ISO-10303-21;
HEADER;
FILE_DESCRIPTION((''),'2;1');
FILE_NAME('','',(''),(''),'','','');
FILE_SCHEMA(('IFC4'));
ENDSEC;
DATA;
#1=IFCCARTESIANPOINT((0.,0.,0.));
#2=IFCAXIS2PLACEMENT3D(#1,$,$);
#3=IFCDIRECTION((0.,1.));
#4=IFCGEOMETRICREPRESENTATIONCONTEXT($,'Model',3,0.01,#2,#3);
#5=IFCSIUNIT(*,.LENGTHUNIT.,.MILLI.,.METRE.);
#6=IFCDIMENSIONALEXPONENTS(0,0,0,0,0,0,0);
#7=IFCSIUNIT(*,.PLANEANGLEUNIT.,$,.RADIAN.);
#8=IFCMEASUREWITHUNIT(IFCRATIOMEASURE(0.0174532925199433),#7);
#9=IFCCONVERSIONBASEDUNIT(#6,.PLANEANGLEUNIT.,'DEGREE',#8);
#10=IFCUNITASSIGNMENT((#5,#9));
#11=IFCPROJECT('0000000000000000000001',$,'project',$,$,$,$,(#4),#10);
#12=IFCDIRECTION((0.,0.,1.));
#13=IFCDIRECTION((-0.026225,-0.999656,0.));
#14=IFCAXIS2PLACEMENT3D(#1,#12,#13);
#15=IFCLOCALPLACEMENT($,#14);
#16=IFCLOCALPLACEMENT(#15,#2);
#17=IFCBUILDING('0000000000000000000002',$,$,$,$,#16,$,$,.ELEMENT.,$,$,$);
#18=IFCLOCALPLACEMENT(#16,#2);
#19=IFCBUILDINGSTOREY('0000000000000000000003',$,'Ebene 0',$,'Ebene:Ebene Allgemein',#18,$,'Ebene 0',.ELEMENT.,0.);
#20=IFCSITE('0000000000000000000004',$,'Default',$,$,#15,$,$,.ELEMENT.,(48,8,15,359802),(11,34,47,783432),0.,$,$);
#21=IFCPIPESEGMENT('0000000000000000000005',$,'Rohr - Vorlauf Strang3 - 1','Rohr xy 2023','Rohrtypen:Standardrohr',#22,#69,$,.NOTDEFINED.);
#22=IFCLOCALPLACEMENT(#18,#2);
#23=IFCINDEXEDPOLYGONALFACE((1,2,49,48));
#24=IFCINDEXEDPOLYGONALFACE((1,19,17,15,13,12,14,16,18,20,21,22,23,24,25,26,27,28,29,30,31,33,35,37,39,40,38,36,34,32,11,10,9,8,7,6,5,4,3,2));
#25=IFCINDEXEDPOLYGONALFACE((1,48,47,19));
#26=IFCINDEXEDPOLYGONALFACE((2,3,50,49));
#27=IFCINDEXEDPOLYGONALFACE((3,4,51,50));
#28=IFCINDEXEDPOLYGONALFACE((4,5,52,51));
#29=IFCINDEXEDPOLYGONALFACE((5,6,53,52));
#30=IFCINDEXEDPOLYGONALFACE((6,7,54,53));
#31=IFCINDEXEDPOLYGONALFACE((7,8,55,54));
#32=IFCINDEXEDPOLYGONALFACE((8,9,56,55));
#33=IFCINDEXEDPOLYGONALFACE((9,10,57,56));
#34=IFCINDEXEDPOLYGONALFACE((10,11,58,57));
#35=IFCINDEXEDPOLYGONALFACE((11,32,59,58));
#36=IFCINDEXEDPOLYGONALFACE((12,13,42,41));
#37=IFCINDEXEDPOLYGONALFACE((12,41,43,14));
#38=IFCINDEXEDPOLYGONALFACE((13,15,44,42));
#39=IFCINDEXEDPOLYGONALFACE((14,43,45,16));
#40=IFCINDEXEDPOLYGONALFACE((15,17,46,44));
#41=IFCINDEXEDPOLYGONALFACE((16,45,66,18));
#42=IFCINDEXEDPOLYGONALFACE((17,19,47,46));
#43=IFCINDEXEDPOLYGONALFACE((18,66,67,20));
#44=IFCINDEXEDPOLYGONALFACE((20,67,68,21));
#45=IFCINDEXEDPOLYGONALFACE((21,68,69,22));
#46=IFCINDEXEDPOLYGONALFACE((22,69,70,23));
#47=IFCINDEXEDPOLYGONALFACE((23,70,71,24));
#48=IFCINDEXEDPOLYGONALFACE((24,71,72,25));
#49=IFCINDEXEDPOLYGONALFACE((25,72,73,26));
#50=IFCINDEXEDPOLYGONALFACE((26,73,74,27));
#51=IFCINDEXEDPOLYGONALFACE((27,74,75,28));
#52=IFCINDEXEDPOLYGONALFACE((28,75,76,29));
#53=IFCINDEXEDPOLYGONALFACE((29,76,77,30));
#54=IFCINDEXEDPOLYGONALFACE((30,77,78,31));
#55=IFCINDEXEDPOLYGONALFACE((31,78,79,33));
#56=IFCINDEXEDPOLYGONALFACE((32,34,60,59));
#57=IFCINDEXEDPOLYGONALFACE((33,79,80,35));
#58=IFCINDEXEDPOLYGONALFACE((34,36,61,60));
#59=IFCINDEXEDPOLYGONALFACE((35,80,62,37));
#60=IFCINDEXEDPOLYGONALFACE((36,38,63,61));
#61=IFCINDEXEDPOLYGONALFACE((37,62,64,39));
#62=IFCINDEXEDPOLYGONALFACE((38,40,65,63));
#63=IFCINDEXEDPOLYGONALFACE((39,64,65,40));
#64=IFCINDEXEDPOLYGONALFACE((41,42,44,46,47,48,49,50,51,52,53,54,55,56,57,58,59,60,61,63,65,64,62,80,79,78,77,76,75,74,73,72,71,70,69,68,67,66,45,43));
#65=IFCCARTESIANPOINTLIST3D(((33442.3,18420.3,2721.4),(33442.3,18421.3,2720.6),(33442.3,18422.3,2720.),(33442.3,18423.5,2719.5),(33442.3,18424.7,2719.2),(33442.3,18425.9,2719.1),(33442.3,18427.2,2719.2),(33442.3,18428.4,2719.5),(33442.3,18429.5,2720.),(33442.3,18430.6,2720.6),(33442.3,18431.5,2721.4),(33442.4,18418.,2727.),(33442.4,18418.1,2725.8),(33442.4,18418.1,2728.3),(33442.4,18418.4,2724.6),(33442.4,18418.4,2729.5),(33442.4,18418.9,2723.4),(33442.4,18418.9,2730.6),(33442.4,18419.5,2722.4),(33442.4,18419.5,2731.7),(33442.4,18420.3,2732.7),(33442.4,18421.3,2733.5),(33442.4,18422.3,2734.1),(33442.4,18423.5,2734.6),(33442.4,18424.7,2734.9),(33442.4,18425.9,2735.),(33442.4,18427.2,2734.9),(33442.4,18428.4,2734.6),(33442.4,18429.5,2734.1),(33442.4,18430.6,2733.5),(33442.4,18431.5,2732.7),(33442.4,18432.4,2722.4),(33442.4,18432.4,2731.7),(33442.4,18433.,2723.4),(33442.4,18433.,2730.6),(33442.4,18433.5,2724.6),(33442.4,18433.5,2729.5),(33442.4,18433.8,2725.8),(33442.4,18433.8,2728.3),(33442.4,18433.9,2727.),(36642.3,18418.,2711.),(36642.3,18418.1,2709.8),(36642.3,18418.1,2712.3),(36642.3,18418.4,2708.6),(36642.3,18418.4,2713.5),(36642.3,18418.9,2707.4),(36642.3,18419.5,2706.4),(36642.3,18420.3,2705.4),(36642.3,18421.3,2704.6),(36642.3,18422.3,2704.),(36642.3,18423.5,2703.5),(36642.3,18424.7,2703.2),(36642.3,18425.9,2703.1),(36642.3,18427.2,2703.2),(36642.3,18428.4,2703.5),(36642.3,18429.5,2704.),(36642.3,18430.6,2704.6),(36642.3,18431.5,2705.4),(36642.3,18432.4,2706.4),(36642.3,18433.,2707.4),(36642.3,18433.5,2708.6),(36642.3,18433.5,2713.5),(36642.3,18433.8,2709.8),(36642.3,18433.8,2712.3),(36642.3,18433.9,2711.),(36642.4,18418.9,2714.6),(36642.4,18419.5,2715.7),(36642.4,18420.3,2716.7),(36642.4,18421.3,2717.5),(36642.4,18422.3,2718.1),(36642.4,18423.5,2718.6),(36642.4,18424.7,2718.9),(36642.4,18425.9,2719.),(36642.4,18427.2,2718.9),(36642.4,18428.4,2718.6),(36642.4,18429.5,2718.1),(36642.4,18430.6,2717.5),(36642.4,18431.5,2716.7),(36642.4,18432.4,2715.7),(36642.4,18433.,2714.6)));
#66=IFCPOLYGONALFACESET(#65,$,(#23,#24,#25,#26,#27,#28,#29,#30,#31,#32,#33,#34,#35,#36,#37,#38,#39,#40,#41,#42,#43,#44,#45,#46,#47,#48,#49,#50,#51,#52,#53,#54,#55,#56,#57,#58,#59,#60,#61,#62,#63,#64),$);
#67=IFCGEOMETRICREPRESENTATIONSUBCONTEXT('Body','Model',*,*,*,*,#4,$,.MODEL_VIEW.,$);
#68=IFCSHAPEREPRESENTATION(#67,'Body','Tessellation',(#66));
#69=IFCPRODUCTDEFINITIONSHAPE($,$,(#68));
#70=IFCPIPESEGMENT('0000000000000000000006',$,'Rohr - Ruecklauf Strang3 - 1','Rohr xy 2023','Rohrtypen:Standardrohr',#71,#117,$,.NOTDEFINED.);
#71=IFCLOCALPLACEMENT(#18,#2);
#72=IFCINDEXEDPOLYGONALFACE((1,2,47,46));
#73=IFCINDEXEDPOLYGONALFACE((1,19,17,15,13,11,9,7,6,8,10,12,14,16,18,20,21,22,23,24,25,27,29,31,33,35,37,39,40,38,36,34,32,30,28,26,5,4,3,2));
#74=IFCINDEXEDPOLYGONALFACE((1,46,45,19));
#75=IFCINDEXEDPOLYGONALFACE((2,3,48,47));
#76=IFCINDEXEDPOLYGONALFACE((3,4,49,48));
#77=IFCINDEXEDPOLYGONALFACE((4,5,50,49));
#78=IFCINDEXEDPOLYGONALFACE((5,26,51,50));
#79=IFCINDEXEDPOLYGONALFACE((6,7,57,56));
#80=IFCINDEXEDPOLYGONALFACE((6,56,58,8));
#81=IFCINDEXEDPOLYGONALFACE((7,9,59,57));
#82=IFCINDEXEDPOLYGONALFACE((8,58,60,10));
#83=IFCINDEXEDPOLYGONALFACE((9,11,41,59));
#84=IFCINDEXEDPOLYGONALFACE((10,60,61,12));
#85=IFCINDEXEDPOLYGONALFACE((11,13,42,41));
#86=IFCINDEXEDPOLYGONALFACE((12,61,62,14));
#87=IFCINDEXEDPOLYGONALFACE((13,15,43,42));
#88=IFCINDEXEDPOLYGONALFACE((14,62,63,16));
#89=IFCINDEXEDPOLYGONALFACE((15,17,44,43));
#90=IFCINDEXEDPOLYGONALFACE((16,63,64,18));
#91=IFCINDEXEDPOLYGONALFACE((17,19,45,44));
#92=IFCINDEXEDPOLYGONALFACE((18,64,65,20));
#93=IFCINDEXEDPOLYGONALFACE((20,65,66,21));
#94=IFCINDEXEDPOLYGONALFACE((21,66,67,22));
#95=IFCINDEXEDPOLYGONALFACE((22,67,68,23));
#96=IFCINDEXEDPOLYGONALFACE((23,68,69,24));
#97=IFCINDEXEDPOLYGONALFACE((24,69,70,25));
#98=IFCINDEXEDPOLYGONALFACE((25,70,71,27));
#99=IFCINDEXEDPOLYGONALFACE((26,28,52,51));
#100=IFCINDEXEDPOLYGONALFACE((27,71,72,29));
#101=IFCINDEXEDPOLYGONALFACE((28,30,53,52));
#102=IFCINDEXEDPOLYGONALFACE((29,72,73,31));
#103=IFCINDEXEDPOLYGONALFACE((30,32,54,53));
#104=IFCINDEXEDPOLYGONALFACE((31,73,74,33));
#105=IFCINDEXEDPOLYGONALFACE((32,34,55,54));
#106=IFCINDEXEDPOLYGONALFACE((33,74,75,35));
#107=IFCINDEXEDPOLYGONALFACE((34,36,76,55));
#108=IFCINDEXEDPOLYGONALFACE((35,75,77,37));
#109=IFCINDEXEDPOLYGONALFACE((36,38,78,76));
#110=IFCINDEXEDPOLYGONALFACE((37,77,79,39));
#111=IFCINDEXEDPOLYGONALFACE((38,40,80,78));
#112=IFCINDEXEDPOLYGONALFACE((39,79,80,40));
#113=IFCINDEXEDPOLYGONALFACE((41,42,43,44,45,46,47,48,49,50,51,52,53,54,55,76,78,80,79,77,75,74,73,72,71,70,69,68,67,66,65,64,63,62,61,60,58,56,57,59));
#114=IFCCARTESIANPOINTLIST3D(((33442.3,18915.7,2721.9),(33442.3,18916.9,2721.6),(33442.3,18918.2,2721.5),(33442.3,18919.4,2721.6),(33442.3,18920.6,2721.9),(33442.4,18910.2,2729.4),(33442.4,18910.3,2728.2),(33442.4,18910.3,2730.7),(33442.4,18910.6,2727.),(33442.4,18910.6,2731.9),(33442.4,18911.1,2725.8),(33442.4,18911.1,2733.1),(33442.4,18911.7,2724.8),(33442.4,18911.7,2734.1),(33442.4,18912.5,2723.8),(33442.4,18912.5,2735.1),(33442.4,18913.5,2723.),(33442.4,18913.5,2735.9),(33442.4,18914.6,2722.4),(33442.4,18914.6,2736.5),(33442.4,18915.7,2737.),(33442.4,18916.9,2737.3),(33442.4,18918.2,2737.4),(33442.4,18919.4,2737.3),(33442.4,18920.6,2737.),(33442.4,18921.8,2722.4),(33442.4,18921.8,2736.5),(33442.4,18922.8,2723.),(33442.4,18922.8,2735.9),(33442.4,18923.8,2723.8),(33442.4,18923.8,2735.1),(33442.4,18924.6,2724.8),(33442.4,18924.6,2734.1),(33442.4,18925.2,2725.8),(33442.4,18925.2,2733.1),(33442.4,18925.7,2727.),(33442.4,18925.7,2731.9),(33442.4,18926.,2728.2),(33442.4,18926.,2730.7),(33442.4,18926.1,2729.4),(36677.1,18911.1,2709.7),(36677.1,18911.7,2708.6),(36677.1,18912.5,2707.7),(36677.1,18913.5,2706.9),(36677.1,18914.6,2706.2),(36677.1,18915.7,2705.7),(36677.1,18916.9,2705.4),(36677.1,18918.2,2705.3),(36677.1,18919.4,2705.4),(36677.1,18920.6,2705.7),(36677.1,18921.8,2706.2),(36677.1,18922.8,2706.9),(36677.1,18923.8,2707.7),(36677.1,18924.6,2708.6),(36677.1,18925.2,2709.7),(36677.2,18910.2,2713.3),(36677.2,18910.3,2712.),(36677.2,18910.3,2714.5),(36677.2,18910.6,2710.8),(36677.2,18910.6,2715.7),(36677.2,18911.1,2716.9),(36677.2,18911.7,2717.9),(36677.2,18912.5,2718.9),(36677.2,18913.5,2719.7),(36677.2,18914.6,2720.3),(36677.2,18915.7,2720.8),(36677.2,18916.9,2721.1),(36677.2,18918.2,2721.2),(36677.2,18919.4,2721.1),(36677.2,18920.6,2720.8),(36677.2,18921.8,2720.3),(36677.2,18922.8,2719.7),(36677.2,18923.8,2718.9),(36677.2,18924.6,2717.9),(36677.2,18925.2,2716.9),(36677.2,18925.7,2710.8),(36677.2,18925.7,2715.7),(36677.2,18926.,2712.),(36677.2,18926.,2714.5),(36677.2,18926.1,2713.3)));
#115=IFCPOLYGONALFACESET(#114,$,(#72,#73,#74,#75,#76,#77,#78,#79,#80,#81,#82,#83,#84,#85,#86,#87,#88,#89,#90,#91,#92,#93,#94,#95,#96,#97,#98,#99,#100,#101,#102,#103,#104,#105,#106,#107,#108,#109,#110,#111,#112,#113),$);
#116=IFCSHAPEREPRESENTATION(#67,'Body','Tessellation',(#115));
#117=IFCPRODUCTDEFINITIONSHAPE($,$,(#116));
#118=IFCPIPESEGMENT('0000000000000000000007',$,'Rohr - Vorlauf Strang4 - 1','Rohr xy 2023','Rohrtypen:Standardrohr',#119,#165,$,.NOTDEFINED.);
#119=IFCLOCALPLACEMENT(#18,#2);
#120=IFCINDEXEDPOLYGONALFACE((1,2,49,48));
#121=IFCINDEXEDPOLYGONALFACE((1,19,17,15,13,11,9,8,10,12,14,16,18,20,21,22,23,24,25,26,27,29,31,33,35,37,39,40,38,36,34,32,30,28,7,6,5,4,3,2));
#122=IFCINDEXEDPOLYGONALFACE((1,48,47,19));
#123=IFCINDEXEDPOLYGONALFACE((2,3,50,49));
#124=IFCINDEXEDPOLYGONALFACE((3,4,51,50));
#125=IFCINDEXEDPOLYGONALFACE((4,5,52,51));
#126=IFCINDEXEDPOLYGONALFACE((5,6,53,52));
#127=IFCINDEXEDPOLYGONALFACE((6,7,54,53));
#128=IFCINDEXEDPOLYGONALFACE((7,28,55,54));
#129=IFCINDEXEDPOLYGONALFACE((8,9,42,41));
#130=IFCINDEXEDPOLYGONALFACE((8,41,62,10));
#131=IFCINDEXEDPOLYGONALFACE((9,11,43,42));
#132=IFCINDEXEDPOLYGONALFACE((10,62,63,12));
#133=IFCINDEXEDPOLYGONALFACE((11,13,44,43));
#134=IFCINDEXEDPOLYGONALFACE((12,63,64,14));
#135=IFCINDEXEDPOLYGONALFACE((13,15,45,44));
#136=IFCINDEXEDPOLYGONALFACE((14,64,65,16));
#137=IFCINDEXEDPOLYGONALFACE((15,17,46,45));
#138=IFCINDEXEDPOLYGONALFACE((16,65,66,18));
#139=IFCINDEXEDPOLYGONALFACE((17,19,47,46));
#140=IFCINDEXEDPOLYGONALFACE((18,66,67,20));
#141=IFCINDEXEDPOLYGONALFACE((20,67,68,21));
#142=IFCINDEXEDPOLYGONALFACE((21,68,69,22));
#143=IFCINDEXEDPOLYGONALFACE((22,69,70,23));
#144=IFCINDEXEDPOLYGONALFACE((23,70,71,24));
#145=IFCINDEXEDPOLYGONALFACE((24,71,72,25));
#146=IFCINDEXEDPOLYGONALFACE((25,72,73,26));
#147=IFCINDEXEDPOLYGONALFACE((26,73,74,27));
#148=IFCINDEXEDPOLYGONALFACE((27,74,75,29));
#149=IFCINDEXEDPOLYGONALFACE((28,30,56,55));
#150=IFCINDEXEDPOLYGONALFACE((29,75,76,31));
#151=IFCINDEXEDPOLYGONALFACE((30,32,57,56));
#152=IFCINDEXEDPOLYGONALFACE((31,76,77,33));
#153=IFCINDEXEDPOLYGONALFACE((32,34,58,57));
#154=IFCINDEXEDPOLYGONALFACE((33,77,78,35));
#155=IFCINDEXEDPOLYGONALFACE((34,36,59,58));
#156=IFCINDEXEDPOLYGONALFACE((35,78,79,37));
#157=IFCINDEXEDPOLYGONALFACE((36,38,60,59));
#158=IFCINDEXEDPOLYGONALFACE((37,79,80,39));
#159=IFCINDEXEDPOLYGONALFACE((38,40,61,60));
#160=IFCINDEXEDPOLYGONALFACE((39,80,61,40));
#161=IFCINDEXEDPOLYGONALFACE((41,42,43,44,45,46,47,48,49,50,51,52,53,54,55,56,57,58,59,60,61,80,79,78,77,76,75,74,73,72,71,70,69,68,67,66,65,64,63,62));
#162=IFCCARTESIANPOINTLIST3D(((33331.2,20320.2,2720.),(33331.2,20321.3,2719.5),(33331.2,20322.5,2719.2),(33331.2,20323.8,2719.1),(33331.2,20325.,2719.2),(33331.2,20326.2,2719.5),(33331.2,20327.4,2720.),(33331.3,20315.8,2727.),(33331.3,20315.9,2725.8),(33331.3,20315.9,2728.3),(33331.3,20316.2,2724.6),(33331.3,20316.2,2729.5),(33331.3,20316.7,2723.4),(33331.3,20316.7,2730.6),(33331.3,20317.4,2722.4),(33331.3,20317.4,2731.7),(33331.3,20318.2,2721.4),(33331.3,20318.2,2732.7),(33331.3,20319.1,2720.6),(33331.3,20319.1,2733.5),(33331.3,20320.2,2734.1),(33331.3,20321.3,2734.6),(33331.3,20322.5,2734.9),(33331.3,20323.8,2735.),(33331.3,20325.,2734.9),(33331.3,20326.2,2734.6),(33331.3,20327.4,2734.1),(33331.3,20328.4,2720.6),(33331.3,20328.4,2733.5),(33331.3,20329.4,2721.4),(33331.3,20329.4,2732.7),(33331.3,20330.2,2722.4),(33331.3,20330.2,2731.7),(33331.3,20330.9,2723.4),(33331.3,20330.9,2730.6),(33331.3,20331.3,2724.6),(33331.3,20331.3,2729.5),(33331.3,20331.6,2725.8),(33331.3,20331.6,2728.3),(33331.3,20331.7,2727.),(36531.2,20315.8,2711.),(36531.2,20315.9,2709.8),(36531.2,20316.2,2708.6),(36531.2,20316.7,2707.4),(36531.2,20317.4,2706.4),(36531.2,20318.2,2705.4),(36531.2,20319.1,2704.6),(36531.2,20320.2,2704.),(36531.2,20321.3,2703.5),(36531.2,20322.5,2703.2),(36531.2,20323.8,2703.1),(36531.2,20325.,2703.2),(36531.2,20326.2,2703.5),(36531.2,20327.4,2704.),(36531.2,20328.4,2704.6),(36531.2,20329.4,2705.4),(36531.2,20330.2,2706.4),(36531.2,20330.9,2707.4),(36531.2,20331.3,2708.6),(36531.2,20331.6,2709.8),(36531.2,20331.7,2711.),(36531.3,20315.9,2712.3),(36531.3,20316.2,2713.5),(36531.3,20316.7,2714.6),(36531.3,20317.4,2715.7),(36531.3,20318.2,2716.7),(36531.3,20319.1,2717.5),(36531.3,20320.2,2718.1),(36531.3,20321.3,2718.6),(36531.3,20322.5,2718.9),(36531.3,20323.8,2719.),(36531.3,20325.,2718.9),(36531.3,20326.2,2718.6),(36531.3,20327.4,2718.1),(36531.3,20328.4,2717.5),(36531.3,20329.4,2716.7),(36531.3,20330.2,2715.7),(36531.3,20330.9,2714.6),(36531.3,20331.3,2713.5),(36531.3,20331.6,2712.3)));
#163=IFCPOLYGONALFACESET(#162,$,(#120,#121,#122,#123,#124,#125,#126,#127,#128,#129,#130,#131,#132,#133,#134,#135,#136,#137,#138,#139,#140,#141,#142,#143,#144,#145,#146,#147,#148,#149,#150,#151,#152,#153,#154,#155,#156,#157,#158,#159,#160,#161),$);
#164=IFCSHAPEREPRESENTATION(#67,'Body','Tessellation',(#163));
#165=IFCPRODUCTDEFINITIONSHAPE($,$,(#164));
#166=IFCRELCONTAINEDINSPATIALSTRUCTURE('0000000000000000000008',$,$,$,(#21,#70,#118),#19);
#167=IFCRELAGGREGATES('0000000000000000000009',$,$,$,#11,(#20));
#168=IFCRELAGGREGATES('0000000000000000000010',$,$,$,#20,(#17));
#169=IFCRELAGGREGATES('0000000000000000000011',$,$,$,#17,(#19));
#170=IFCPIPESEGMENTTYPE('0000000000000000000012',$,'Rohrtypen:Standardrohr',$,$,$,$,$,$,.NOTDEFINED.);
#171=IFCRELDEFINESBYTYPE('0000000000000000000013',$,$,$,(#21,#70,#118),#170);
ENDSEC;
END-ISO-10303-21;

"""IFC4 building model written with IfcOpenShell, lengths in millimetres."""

from ifc_helpers import new_model, entity, si_unit, converted_unit, direction, frame, origin, place, context, subcontext, project, spatial, indexed_curve, outline, extrude, type_object, element, save


model = new_model("IFC4")

# Units and contexts
model_context = context("Model", 3, precision=0.01, world=origin(), true_north=direction((0.0, 1.0)))
body_context = subcontext(model_context, "Body", "Model", "MODEL_VIEW")
ifc_project = project(units=[si_unit("LENGTHUNIT", "METRE", prefix="MILLI"), converted_unit("PLANEANGLEUNIT", "DEGREE", entity("IfcRatioMeasure", 0.0174532925199433), si_unit("PLANEANGLEUNIT", "RADIAN"), dimensions=[0, 0, 0, 0, 0, 0, 0])], contexts=[model_context])

# Site, building, storey
site_placement = place(None, frame((0.0, 0.0, 0.0), z_axis=(0.0, 0.0, 1.0), x_axis=(-0.026225, -0.999656, 0.0)))
site = spatial("IfcSite", under=ifc_project, at=site_placement, Name="Default", CompositionType="ELEMENT", RefLatitude=(48, 8, 15, 359802), RefLongitude=(11, 34, 47, 783432), RefElevation=0.0)
building_placement = place(site_placement, origin())
building = spatial("IfcBuilding", under=site, at=building_placement, CompositionType="ELEMENT")
storey_placement = place(building_placement, origin())
storey = spatial("IfcBuildingStorey", under=building, at=storey_placement, Name="Ebene 0", ObjectType="Ebene:Ebene Allgemein", LongName="Ebene 0", CompositionType="ELEMENT", Elevation=0.0)

# Pipe segments
pipe_segment_type = type_object("IfcPipeSegmentType", Name="Rohrtypen:Standardrohr", PredefinedType="NOTDEFINED")
pipe_segment_1_placement = place(storey_placement, origin())
element("IfcPipeSegment", 1, at=pipe_segment_1_placement, inside=storey, type_object=pipe_segment_type, Name="Rohr - Vorlauf Strang3 - 1", Description="Rohr xy 2023", ObjectType="Rohrtypen:Standardrohr", PredefinedType="NOTDEFINED", context=body_context, shape_type="SweptSolid", body=[
    extrude(outline(indexed_curve([(7.9, 0.0), (7.8, 1.2), (7.6, 2.5), (7.1, 3.6), (6.4, 4.7), (5.6, 5.6), (4.7, 6.4), (3.6, 7.1), (2.5, 7.6), (1.2, 7.8), (0.0, 7.9), (-1.2, 7.8), (-2.5, 7.6), (-3.6, 7.1), (-4.7, 6.4), (-5.6, 5.6), (-6.4, 4.7), (-7.1, 3.6), (-7.6, 2.5), (-7.8, 1.2), (-7.9, 0.0), (-7.8, -1.2), (-7.6, -2.5), (-7.1, -3.6), (-6.4, -4.7), (-5.6, -5.6), (-4.7, -6.4), (-3.6, -7.1), (-2.5, -7.6), (-1.2, -7.8), (0.0, -7.9), (1.2, -7.8), (2.5, -7.6), (3.6, -7.1), (4.7, -6.4), (5.6, -5.6), (6.4, -4.7), (7.1, -3.6), (7.6, -2.5), (7.8, -1.2), (7.9, 0.0)], self_intersect=False)), frame((36642.3, 18425.9, 2711.0), z_axis=(-0.999988, 0.0, 0.005), x_axis=(0.0, 1.0, 0.0)), (0.0, 0.0, 1.0), 3200.0),
])
pipe_segment_2_placement = place(storey_placement, origin())
element("IfcPipeSegment", 2, at=pipe_segment_2_placement, inside=storey, type_object=pipe_segment_type, Name="Rohr - Ruecklauf Strang3 - 1", Description="Rohr xy 2023", ObjectType="Rohrtypen:Standardrohr", PredefinedType="NOTDEFINED", context=body_context, shape_type="SweptSolid", body=[
    extrude(outline(indexed_curve([(7.9, 0.0), (7.8, 1.2), (7.6, 2.5), (7.1, 3.6), (6.4, 4.7), (5.6, 5.6), (4.7, 6.4), (3.6, 7.1), (2.5, 7.6), (1.2, 7.8), (0.0, 7.9), (-1.2, 7.8), (-2.5, 7.6), (-3.6, 7.1), (-4.7, 6.4), (-5.6, 5.6), (-6.4, 4.7), (-7.1, 3.6), (-7.6, 2.5), (-7.8, 1.2), (-7.9, 0.0), (-7.8, -1.2), (-7.6, -2.5), (-7.1, -3.6), (-6.4, -4.7), (-5.6, -5.6), (-4.7, -6.4), (-3.6, -7.1), (-2.5, -7.6), (-1.2, -7.8), (0.0, -7.9), (1.2, -7.8), (2.5, -7.6), (3.6, -7.1), (4.7, -6.4), (5.6, -5.6), (6.4, -4.7), (7.1, -3.6), (7.6, -2.5), (7.8, -1.2), (7.9, 0.0)], self_intersect=False)), frame((36677.2, 18918.2, 2713.3), z_axis=(-0.999988, 0.0, 0.005), x_axis=(0.0, 1.0, 0.0)), (0.0, 0.0, 1.0), 3234.8),
])
pipe_segment_3_placement = place(storey_placement, origin())
element("IfcPipeSegment", 3, at=pipe_segment_3_placement, inside=storey, type_object=pipe_segment_type, Name="Rohr - Vorlauf Strang4 - 1", Description="Rohr xy 2023", ObjectType="Rohrtypen:Standardrohr", PredefinedType="NOTDEFINED", context=body_context, shape_type="SweptSolid", body=[
    extrude(outline(indexed_curve([(7.9, 0.0), (7.8, 1.2), (7.6, 2.5), (7.1, 3.6), (6.4, 4.7), (5.6, 5.6), (4.7, 6.4), (3.6, 7.1), (2.5, 7.6), (1.2, 7.8), (0.0, 7.9), (-1.2, 7.8), (-2.5, 7.6), (-3.6, 7.1), (-4.7, 6.4), (-5.6, 5.6), (-6.4, 4.7), (-7.1, 3.6), (-7.6, 2.5), (-7.8, 1.2), (-7.9, 0.0), (-7.8, -1.2), (-7.6, -2.5), (-7.1, -3.6), (-6.4, -4.7), (-5.6, -5.6), (-4.7, -6.4), (-3.6, -7.1), (-2.5, -7.6), (-1.2, -7.8), (0.0, -7.9), (1.2, -7.8), (2.5, -7.6), (3.6, -7.1), (4.7, -6.4), (5.6, -5.6), (6.4, -4.7), (7.1, -3.6), (7.6, -2.5), (7.8, -1.2), (7.9, 0.0)], self_intersect=False)), frame((36531.2, 20323.8, 2711.0), z_axis=(-0.999988, 0.0, 0.005), x_axis=(0.0, 1.0, 0.0)), (0.0, 0.0, 1.0), 3200.0),
])

save(model, "model.ifc")
